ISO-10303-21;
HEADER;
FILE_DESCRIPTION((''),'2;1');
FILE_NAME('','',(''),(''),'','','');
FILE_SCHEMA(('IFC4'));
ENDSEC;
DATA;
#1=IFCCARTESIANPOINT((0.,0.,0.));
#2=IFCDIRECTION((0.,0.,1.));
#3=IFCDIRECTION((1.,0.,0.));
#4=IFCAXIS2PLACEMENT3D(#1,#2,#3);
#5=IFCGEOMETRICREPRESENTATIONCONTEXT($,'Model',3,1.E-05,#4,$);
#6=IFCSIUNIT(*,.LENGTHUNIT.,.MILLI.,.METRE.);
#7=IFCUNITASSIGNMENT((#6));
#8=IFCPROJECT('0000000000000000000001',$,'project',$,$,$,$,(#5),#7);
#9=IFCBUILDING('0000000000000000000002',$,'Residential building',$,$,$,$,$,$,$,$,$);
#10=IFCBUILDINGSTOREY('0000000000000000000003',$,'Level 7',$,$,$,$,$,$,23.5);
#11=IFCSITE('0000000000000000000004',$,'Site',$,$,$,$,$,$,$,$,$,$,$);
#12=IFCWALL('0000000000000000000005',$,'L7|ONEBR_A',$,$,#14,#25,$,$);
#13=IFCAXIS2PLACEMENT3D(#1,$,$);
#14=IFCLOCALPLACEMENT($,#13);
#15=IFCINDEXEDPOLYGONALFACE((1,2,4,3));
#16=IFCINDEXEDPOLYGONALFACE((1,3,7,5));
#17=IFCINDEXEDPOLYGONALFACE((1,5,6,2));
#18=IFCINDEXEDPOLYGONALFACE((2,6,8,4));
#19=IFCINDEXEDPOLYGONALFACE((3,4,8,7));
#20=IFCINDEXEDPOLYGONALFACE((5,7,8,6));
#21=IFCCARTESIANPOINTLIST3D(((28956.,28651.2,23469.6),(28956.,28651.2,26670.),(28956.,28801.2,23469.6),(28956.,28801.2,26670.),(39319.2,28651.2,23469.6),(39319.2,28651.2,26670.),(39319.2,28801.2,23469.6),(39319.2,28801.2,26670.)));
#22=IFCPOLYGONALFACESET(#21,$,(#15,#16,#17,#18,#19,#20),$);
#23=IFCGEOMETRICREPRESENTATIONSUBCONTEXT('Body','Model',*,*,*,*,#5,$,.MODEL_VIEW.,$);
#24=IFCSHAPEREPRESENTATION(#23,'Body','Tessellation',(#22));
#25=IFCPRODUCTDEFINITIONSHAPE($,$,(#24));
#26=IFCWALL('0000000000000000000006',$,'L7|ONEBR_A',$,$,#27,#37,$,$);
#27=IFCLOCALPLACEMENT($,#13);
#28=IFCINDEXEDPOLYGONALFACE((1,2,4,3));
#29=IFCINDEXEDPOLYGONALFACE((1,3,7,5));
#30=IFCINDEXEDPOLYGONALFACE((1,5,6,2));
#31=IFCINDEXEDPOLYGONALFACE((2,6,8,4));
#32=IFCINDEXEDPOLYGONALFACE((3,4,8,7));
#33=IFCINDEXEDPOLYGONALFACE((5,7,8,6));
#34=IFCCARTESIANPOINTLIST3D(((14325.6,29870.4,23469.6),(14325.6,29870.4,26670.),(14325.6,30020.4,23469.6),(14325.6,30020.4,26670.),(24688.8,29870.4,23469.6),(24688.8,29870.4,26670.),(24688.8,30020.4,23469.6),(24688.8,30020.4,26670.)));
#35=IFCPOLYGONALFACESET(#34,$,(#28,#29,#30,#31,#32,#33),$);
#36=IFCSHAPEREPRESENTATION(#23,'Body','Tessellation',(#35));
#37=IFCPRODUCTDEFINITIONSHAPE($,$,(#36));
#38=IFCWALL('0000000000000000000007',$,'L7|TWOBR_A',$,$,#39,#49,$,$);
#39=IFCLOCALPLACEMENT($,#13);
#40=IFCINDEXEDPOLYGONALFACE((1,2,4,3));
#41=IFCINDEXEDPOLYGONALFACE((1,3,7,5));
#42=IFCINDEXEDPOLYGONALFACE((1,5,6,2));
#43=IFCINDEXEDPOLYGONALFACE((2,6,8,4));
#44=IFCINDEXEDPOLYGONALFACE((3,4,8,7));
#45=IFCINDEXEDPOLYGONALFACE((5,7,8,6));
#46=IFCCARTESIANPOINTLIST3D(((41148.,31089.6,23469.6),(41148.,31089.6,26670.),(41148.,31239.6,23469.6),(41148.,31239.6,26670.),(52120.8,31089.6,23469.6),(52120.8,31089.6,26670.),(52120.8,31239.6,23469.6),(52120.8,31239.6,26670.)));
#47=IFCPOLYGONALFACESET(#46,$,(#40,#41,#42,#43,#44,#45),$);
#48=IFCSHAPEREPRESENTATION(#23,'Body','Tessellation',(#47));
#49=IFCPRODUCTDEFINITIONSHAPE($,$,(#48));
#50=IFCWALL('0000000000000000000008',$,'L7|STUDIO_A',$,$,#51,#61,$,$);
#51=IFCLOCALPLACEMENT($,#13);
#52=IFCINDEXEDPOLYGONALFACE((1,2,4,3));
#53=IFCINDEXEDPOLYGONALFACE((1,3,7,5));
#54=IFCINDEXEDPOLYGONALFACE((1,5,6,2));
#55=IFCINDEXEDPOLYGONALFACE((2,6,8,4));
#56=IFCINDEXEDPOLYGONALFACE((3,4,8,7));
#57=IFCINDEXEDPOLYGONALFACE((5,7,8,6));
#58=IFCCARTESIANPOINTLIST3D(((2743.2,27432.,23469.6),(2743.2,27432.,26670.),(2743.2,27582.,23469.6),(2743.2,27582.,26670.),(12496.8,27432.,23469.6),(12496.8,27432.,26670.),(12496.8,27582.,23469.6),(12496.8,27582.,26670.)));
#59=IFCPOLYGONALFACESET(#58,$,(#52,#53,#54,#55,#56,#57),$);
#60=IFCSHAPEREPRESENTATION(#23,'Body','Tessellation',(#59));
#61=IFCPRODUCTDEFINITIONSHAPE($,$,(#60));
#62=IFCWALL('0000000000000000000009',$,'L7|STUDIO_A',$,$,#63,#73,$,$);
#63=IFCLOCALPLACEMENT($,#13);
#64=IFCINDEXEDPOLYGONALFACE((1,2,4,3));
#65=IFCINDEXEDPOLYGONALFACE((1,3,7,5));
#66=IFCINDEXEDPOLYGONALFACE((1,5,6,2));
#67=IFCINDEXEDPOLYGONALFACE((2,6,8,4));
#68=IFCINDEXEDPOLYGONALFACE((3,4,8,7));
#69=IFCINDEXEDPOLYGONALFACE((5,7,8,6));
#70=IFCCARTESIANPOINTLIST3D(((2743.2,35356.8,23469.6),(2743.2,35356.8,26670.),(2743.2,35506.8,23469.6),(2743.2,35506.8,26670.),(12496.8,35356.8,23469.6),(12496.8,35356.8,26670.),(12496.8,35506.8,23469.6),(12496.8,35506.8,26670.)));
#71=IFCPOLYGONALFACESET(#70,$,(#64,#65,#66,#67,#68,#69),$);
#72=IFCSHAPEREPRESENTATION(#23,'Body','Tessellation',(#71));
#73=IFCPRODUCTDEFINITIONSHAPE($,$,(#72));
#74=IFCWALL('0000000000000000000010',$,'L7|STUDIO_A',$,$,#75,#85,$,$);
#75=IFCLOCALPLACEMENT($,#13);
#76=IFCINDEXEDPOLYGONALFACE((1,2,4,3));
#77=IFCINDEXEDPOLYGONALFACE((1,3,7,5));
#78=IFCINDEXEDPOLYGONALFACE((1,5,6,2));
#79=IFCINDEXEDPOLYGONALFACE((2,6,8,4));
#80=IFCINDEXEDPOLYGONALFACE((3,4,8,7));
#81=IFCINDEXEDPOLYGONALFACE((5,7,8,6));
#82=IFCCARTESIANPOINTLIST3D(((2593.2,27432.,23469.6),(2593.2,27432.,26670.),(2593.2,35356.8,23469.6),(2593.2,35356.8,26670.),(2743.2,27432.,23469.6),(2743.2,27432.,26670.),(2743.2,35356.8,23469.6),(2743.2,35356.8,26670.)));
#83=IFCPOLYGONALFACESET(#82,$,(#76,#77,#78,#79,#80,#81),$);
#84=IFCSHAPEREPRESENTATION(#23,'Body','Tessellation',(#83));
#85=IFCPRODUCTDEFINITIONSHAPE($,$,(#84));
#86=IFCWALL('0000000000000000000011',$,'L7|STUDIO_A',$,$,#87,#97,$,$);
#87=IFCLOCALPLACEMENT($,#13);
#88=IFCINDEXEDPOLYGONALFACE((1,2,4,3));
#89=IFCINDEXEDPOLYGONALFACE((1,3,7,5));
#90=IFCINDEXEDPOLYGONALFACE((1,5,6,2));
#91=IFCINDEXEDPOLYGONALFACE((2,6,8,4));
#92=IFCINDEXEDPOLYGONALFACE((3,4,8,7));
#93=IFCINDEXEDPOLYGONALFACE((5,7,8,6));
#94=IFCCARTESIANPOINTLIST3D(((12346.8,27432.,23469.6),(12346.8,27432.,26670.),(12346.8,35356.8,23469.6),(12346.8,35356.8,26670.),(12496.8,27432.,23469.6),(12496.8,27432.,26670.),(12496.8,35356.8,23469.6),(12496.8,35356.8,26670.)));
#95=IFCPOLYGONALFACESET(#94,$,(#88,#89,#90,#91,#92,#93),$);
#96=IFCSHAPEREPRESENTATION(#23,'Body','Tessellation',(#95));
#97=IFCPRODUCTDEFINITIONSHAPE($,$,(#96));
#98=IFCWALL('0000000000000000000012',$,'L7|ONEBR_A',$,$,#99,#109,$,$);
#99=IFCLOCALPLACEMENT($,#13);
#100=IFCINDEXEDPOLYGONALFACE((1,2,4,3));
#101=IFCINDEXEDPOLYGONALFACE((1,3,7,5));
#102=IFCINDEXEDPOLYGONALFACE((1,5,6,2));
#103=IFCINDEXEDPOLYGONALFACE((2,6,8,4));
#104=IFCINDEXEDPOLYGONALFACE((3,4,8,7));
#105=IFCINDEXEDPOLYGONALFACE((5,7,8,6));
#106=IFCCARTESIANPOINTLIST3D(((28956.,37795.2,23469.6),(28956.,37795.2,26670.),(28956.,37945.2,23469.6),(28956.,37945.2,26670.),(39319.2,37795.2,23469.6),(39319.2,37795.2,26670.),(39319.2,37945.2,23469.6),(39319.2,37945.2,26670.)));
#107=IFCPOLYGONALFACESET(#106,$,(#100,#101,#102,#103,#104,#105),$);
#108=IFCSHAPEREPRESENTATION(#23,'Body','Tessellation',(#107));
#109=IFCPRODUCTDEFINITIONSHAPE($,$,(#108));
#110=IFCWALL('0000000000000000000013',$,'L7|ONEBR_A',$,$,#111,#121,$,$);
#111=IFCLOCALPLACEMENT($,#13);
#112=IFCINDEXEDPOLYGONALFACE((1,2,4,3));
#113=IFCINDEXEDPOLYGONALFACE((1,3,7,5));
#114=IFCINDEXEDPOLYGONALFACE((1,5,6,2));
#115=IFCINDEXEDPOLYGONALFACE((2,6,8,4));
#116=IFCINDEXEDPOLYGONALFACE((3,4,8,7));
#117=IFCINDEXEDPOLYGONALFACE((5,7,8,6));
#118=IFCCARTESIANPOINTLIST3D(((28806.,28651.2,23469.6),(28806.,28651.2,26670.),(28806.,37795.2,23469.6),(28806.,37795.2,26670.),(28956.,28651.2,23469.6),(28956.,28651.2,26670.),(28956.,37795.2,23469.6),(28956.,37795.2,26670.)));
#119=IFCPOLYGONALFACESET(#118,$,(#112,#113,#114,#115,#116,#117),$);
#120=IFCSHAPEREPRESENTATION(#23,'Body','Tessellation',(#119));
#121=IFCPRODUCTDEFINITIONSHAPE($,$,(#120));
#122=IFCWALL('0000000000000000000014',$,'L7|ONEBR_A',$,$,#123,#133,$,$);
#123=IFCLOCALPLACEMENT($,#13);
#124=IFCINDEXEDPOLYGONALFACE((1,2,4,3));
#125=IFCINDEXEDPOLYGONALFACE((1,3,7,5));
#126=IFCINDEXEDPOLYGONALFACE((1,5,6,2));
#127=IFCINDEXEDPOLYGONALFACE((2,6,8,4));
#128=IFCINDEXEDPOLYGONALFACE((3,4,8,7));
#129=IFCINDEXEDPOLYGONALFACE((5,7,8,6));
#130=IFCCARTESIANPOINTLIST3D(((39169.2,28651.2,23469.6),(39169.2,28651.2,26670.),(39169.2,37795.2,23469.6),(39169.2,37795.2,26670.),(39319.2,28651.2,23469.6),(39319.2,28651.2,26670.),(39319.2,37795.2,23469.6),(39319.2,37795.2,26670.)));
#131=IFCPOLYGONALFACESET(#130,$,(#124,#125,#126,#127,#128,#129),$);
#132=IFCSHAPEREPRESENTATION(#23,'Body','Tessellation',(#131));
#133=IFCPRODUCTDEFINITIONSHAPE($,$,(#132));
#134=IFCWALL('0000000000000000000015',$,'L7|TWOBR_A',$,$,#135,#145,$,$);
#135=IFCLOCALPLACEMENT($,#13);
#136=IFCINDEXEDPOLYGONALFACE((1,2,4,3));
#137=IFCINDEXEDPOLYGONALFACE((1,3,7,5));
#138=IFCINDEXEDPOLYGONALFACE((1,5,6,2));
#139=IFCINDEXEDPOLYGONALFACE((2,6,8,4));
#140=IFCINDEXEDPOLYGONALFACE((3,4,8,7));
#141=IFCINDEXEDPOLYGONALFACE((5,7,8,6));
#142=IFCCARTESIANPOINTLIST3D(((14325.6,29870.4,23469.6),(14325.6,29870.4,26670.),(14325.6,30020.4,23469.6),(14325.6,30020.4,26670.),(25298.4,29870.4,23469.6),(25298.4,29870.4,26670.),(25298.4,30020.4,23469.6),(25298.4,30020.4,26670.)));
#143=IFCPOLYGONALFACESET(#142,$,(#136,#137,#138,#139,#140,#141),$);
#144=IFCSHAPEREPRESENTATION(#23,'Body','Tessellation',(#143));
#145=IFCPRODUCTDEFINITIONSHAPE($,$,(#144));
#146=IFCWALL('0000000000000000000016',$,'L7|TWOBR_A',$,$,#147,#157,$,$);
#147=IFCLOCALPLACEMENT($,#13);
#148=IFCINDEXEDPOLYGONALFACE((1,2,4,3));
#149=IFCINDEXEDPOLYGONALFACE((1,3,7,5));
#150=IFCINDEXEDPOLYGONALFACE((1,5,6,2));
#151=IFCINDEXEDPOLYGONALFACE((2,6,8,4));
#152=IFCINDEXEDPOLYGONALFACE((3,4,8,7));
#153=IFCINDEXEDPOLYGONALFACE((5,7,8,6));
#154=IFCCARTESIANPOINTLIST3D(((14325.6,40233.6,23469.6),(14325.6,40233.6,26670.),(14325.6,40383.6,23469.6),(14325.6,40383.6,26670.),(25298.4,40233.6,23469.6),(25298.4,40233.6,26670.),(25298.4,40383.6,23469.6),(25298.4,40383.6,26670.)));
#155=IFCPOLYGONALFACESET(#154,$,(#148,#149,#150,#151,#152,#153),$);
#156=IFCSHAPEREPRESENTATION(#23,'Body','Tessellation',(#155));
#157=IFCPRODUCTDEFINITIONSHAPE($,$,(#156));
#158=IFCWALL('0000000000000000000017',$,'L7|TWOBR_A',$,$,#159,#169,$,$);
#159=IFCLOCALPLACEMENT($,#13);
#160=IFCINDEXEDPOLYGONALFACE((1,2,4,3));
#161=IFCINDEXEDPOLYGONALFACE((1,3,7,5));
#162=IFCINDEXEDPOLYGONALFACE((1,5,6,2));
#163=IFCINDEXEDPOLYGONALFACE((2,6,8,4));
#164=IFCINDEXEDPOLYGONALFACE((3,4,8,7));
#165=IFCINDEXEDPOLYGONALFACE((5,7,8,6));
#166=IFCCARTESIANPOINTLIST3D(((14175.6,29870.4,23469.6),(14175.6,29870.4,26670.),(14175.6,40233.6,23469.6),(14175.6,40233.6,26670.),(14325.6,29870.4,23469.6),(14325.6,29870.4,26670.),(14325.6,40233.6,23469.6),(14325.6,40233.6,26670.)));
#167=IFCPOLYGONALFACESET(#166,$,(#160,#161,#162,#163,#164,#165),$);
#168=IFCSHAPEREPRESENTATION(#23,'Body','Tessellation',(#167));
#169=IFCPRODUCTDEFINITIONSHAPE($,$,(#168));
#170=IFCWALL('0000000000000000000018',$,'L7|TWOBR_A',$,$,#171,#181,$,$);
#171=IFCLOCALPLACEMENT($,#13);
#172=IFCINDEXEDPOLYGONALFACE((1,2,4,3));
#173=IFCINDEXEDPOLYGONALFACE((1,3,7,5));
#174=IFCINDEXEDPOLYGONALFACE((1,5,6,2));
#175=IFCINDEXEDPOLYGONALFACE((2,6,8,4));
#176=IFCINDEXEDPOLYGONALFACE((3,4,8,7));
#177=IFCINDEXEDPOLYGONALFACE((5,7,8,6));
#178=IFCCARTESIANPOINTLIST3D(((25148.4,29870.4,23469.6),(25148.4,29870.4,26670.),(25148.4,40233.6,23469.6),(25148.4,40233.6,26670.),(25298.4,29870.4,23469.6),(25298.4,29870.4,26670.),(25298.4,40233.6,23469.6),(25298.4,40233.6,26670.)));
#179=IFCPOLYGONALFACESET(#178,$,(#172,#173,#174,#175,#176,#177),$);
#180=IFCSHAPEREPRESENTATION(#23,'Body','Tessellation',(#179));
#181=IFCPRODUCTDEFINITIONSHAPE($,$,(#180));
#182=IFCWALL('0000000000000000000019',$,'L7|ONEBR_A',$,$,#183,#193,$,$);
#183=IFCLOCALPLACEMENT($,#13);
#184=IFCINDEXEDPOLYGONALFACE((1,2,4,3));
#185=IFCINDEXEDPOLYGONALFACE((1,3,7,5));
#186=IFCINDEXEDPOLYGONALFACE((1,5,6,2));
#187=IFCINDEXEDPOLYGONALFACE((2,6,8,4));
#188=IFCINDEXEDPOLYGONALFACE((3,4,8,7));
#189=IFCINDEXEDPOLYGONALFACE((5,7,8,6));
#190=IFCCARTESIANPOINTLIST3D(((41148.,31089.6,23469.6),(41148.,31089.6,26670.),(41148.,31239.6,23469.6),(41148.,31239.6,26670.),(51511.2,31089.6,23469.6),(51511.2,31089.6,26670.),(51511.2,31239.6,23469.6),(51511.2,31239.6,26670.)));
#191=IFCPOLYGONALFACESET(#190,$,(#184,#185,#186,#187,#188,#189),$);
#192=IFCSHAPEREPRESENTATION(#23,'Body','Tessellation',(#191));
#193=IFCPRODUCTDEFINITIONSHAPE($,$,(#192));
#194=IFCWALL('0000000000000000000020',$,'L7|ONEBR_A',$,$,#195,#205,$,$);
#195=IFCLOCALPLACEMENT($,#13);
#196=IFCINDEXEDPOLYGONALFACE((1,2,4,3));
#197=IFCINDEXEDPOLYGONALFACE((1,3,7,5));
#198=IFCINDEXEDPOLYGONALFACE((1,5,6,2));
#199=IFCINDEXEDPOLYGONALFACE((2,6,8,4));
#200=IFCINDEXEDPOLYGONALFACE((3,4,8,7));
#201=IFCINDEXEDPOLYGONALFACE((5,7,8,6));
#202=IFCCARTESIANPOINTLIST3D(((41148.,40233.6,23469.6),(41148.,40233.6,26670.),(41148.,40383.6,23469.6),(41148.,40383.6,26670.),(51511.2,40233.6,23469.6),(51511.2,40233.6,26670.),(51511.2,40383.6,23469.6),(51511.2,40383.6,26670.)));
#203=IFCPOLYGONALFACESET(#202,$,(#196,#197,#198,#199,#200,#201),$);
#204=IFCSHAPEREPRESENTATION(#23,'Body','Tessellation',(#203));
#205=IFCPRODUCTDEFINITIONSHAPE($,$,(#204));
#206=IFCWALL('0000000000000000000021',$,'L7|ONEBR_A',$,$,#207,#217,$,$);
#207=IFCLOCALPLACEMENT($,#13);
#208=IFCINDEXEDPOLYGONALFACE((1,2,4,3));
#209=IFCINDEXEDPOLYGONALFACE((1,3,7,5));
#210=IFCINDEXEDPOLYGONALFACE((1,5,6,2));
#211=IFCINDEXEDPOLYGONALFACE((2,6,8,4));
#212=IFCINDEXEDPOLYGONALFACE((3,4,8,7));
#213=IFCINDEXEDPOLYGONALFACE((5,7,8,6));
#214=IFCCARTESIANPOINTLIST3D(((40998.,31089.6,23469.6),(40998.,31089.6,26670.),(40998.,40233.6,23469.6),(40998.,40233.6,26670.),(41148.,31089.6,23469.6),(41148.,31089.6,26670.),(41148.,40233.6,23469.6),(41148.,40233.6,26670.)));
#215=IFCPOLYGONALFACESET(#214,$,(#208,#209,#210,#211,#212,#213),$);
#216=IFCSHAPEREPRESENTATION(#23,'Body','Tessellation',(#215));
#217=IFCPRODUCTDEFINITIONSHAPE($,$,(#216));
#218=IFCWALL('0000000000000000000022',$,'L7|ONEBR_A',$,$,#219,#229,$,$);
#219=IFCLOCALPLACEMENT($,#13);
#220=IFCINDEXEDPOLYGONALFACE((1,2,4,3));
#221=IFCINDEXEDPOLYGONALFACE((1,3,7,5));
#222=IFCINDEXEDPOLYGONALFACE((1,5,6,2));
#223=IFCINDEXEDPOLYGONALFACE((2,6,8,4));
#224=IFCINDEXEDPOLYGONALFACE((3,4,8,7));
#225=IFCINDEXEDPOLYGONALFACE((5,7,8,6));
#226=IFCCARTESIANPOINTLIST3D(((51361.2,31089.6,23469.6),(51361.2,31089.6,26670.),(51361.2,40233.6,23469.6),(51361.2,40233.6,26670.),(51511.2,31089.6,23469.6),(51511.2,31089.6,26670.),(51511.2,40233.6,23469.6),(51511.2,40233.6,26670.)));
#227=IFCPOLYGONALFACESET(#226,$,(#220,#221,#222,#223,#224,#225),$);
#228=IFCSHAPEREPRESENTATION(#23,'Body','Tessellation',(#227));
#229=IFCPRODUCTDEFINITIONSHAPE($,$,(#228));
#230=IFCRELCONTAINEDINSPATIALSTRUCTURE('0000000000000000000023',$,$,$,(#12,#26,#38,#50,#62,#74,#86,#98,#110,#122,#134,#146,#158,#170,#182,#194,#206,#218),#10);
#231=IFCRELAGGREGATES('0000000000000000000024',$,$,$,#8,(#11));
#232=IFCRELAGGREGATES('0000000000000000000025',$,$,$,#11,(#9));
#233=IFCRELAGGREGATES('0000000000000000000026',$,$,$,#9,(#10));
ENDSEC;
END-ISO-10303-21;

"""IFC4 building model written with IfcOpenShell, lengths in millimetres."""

from ifc_helpers import new_model, si_unit, frame, origin_with_axes, place, context, subcontext, project, spatial, indexed_curve, outline, extrude, element, save


model = new_model("IFC4")

# Units and contexts
model_context = context("Model", 3, precision=1e-05, world=origin_with_axes())
body_context = subcontext(model_context, "Body", "Model", "MODEL_VIEW")
ifc_project = project(units=[si_unit("LENGTHUNIT", "METRE", prefix="MILLI")], contexts=[model_context])

# Site, building, storey
site = spatial("IfcSite", under=ifc_project, Name="Site")
building = spatial("IfcBuilding", under=site, Name="Residential building")
storey = spatial("IfcBuildingStorey", under=building, Name="Level 7", Elevation=23.5)

# Walls
for number, where, z_axis, x_axis, name in (
    (1, (28956.0, 28651.2, 23469.6), (0.0, 0.0, 1.0), (1.0, 0.0, 0.0), "L7|ONEBR_A"),
    (2, (14325.6, 29870.4, 23469.6), (0.0, 0.0, 1.0), (1.0, 0.0, 0.0), "L7|ONEBR_A"),
):
    element("IfcWall", number, at=place(None, frame(where, z_axis=z_axis, x_axis=x_axis)), inside=storey, Name=name, context=body_context, shape_type="SweptSolid", body=[
        extrude(outline(indexed_curve([(0.0, 0.0), (0.0, 150.0), (10363.2, 150.0), (10363.2, 0.0), (0.0, 0.0)], self_intersect=False)), origin_with_axes(), (0.0, 0.0, 1.0), 3200.4),
    ])
wall_placement = place(None, frame((41148.0, 31089.6, 23469.6), z_axis=(0.0, 0.0, 1.0), x_axis=(1.0, 0.0, 0.0)))
element("IfcWall", 3, at=wall_placement, inside=storey, Name="L7|TWOBR_A", context=body_context, shape_type="SweptSolid", body=[
    extrude(outline(indexed_curve([(0.0, 0.0), (0.0, 150.0), (10972.8, 150.0), (10972.8, 0.0), (0.0, 0.0)], self_intersect=False)), origin_with_axes(), (0.0, 0.0, 1.0), 3200.4),
])
for number, where, z_axis, x_axis, name in (
    (4, (2743.2, 27432.0, 23469.6), (0.0, 0.0, 1.0), (1.0, 0.0, 0.0), "L7|STUDIO_A"),
    (5, (2743.2, 35356.8, 23469.6), (0.0, 0.0, 1.0), (1.0, 0.0, 0.0), "L7|STUDIO_A"),
):
    element("IfcWall", number, at=place(None, frame(where, z_axis=z_axis, x_axis=x_axis)), inside=storey, Name=name, context=body_context, shape_type="SweptSolid", body=[
        extrude(outline(indexed_curve([(0.0, 0.0), (0.0, 150.0), (9753.6, 150.0), (9753.6, 0.0), (0.0, 0.0)], self_intersect=False)), origin_with_axes(), (0.0, 0.0, 1.0), 3200.4),
    ])
for number, where, z_axis, x_axis, name in (
    (6, (2743.2, 27432.0, 23469.6), (0.0, 0.0, 1.0), (0.0, 1.0, 0.0), "L7|STUDIO_A"),
    (7, (12496.8, 27432.0, 23469.6), (0.0, 0.0, 1.0), (0.0, 1.0, 0.0), "L7|STUDIO_A"),
):
    element("IfcWall", number, at=place(None, frame(where, z_axis=z_axis, x_axis=x_axis)), inside=storey, Name=name, context=body_context, shape_type="SweptSolid", body=[
        extrude(outline(indexed_curve([(0.0, 0.0), (0.0, 150.0), (7924.8, 150.0), (7924.8, 0.0), (0.0, 0.0)], self_intersect=False)), origin_with_axes(), (0.0, 0.0, 1.0), 3200.4),
    ])
for number, where, z_axis, x_axis, name in (
    (8, (28956.0, 37795.2, 23469.6), (0.0, 0.0, 1.0), (1.0, 0.0, 0.0), "L7|ONEBR_A"),
):
    element("IfcWall", number, at=place(None, frame(where, z_axis=z_axis, x_axis=x_axis)), inside=storey, Name=name, context=body_context, shape_type="SweptSolid", body=[
        extrude(outline(indexed_curve([(0.0, 0.0), (0.0, 150.0), (10363.2, 150.0), (10363.2, 0.0), (0.0, 0.0)], self_intersect=False)), origin_with_axes(), (0.0, 0.0, 1.0), 3200.4),
    ])
for number, where, z_axis, x_axis, name in (
    (9, (28956.0, 28651.2, 23469.6), (0.0, 0.0, 1.0), (0.0, 1.0, 0.0), "L7|ONEBR_A"),
    (10, (39319.2, 28651.2, 23469.6), (0.0, 0.0, 1.0), (0.0, 1.0, 0.0), "L7|ONEBR_A"),
):
    element("IfcWall", number, at=place(None, frame(where, z_axis=z_axis, x_axis=x_axis)), inside=storey, Name=name, context=body_context, shape_type="SweptSolid", body=[
        extrude(outline(indexed_curve([(0.0, 0.0), (0.0, 150.0), (9144.0, 150.0), (9144.0, 0.0), (0.0, 0.0)], self_intersect=False)), origin_with_axes(), (0.0, 0.0, 1.0), 3200.4),
    ])
for number, where, z_axis, x_axis, name in (
    (11, (14325.6, 29870.4, 23469.6), (0.0, 0.0, 1.0), (1.0, 0.0, 0.0), "L7|TWOBR_A"),
    (12, (14325.6, 40233.6, 23469.6), (0.0, 0.0, 1.0), (1.0, 0.0, 0.0), "L7|TWOBR_A"),
):
    element("IfcWall", number, at=place(None, frame(where, z_axis=z_axis, x_axis=x_axis)), inside=storey, Name=name, context=body_context, shape_type="SweptSolid", body=[
        extrude(outline(indexed_curve([(0.0, 0.0), (0.0, 150.0), (10972.8, 150.0), (10972.8, 0.0), (0.0, 0.0)], self_intersect=False)), origin_with_axes(), (0.0, 0.0, 1.0), 3200.4),
    ])
for number, where, z_axis, x_axis, name in (
    (13, (14325.6, 29870.4, 23469.6), (0.0, 0.0, 1.0), (0.0, 1.0, 0.0), "L7|TWOBR_A"),
    (14, (25298.4, 29870.4, 23469.6), (0.0, 0.0, 1.0), (0.0, 1.0, 0.0), "L7|TWOBR_A"),
    (15, (41148.0, 31089.6, 23469.6), (0.0, 0.0, 1.0), (1.0, 0.0, 0.0), "L7|ONEBR_A"),
    (16, (41148.0, 40233.6, 23469.6), (0.0, 0.0, 1.0), (1.0, 0.0, 0.0), "L7|ONEBR_A"),
):
    element("IfcWall", number, at=place(None, frame(where, z_axis=z_axis, x_axis=x_axis)), inside=storey, Name=name, context=body_context, shape_type="SweptSolid", body=[
        extrude(outline(indexed_curve([(0.0, 0.0), (0.0, 150.0), (10363.2, 150.0), (10363.2, 0.0), (0.0, 0.0)], self_intersect=False)), origin_with_axes(), (0.0, 0.0, 1.0), 3200.4),
    ])
for number, where, z_axis, x_axis, name in (
    (17, (41148.0, 31089.6, 23469.6), (0.0, 0.0, 1.0), (0.0, 1.0, 0.0), "L7|ONEBR_A"),
    (18, (51511.2, 31089.6, 23469.6), (0.0, 0.0, 1.0), (0.0, 1.0, 0.0), "L7|ONEBR_A"),
):
    element("IfcWall", number, at=place(None, frame(where, z_axis=z_axis, x_axis=x_axis)), inside=storey, Name=name, context=body_context, shape_type="SweptSolid", body=[
        extrude(outline(indexed_curve([(0.0, 0.0), (0.0, 150.0), (9144.0, 150.0), (9144.0, 0.0), (0.0, 0.0)], self_intersect=False)), origin_with_axes(), (0.0, 0.0, 1.0), 3200.4),
    ])

save(model, "model.ifc")
